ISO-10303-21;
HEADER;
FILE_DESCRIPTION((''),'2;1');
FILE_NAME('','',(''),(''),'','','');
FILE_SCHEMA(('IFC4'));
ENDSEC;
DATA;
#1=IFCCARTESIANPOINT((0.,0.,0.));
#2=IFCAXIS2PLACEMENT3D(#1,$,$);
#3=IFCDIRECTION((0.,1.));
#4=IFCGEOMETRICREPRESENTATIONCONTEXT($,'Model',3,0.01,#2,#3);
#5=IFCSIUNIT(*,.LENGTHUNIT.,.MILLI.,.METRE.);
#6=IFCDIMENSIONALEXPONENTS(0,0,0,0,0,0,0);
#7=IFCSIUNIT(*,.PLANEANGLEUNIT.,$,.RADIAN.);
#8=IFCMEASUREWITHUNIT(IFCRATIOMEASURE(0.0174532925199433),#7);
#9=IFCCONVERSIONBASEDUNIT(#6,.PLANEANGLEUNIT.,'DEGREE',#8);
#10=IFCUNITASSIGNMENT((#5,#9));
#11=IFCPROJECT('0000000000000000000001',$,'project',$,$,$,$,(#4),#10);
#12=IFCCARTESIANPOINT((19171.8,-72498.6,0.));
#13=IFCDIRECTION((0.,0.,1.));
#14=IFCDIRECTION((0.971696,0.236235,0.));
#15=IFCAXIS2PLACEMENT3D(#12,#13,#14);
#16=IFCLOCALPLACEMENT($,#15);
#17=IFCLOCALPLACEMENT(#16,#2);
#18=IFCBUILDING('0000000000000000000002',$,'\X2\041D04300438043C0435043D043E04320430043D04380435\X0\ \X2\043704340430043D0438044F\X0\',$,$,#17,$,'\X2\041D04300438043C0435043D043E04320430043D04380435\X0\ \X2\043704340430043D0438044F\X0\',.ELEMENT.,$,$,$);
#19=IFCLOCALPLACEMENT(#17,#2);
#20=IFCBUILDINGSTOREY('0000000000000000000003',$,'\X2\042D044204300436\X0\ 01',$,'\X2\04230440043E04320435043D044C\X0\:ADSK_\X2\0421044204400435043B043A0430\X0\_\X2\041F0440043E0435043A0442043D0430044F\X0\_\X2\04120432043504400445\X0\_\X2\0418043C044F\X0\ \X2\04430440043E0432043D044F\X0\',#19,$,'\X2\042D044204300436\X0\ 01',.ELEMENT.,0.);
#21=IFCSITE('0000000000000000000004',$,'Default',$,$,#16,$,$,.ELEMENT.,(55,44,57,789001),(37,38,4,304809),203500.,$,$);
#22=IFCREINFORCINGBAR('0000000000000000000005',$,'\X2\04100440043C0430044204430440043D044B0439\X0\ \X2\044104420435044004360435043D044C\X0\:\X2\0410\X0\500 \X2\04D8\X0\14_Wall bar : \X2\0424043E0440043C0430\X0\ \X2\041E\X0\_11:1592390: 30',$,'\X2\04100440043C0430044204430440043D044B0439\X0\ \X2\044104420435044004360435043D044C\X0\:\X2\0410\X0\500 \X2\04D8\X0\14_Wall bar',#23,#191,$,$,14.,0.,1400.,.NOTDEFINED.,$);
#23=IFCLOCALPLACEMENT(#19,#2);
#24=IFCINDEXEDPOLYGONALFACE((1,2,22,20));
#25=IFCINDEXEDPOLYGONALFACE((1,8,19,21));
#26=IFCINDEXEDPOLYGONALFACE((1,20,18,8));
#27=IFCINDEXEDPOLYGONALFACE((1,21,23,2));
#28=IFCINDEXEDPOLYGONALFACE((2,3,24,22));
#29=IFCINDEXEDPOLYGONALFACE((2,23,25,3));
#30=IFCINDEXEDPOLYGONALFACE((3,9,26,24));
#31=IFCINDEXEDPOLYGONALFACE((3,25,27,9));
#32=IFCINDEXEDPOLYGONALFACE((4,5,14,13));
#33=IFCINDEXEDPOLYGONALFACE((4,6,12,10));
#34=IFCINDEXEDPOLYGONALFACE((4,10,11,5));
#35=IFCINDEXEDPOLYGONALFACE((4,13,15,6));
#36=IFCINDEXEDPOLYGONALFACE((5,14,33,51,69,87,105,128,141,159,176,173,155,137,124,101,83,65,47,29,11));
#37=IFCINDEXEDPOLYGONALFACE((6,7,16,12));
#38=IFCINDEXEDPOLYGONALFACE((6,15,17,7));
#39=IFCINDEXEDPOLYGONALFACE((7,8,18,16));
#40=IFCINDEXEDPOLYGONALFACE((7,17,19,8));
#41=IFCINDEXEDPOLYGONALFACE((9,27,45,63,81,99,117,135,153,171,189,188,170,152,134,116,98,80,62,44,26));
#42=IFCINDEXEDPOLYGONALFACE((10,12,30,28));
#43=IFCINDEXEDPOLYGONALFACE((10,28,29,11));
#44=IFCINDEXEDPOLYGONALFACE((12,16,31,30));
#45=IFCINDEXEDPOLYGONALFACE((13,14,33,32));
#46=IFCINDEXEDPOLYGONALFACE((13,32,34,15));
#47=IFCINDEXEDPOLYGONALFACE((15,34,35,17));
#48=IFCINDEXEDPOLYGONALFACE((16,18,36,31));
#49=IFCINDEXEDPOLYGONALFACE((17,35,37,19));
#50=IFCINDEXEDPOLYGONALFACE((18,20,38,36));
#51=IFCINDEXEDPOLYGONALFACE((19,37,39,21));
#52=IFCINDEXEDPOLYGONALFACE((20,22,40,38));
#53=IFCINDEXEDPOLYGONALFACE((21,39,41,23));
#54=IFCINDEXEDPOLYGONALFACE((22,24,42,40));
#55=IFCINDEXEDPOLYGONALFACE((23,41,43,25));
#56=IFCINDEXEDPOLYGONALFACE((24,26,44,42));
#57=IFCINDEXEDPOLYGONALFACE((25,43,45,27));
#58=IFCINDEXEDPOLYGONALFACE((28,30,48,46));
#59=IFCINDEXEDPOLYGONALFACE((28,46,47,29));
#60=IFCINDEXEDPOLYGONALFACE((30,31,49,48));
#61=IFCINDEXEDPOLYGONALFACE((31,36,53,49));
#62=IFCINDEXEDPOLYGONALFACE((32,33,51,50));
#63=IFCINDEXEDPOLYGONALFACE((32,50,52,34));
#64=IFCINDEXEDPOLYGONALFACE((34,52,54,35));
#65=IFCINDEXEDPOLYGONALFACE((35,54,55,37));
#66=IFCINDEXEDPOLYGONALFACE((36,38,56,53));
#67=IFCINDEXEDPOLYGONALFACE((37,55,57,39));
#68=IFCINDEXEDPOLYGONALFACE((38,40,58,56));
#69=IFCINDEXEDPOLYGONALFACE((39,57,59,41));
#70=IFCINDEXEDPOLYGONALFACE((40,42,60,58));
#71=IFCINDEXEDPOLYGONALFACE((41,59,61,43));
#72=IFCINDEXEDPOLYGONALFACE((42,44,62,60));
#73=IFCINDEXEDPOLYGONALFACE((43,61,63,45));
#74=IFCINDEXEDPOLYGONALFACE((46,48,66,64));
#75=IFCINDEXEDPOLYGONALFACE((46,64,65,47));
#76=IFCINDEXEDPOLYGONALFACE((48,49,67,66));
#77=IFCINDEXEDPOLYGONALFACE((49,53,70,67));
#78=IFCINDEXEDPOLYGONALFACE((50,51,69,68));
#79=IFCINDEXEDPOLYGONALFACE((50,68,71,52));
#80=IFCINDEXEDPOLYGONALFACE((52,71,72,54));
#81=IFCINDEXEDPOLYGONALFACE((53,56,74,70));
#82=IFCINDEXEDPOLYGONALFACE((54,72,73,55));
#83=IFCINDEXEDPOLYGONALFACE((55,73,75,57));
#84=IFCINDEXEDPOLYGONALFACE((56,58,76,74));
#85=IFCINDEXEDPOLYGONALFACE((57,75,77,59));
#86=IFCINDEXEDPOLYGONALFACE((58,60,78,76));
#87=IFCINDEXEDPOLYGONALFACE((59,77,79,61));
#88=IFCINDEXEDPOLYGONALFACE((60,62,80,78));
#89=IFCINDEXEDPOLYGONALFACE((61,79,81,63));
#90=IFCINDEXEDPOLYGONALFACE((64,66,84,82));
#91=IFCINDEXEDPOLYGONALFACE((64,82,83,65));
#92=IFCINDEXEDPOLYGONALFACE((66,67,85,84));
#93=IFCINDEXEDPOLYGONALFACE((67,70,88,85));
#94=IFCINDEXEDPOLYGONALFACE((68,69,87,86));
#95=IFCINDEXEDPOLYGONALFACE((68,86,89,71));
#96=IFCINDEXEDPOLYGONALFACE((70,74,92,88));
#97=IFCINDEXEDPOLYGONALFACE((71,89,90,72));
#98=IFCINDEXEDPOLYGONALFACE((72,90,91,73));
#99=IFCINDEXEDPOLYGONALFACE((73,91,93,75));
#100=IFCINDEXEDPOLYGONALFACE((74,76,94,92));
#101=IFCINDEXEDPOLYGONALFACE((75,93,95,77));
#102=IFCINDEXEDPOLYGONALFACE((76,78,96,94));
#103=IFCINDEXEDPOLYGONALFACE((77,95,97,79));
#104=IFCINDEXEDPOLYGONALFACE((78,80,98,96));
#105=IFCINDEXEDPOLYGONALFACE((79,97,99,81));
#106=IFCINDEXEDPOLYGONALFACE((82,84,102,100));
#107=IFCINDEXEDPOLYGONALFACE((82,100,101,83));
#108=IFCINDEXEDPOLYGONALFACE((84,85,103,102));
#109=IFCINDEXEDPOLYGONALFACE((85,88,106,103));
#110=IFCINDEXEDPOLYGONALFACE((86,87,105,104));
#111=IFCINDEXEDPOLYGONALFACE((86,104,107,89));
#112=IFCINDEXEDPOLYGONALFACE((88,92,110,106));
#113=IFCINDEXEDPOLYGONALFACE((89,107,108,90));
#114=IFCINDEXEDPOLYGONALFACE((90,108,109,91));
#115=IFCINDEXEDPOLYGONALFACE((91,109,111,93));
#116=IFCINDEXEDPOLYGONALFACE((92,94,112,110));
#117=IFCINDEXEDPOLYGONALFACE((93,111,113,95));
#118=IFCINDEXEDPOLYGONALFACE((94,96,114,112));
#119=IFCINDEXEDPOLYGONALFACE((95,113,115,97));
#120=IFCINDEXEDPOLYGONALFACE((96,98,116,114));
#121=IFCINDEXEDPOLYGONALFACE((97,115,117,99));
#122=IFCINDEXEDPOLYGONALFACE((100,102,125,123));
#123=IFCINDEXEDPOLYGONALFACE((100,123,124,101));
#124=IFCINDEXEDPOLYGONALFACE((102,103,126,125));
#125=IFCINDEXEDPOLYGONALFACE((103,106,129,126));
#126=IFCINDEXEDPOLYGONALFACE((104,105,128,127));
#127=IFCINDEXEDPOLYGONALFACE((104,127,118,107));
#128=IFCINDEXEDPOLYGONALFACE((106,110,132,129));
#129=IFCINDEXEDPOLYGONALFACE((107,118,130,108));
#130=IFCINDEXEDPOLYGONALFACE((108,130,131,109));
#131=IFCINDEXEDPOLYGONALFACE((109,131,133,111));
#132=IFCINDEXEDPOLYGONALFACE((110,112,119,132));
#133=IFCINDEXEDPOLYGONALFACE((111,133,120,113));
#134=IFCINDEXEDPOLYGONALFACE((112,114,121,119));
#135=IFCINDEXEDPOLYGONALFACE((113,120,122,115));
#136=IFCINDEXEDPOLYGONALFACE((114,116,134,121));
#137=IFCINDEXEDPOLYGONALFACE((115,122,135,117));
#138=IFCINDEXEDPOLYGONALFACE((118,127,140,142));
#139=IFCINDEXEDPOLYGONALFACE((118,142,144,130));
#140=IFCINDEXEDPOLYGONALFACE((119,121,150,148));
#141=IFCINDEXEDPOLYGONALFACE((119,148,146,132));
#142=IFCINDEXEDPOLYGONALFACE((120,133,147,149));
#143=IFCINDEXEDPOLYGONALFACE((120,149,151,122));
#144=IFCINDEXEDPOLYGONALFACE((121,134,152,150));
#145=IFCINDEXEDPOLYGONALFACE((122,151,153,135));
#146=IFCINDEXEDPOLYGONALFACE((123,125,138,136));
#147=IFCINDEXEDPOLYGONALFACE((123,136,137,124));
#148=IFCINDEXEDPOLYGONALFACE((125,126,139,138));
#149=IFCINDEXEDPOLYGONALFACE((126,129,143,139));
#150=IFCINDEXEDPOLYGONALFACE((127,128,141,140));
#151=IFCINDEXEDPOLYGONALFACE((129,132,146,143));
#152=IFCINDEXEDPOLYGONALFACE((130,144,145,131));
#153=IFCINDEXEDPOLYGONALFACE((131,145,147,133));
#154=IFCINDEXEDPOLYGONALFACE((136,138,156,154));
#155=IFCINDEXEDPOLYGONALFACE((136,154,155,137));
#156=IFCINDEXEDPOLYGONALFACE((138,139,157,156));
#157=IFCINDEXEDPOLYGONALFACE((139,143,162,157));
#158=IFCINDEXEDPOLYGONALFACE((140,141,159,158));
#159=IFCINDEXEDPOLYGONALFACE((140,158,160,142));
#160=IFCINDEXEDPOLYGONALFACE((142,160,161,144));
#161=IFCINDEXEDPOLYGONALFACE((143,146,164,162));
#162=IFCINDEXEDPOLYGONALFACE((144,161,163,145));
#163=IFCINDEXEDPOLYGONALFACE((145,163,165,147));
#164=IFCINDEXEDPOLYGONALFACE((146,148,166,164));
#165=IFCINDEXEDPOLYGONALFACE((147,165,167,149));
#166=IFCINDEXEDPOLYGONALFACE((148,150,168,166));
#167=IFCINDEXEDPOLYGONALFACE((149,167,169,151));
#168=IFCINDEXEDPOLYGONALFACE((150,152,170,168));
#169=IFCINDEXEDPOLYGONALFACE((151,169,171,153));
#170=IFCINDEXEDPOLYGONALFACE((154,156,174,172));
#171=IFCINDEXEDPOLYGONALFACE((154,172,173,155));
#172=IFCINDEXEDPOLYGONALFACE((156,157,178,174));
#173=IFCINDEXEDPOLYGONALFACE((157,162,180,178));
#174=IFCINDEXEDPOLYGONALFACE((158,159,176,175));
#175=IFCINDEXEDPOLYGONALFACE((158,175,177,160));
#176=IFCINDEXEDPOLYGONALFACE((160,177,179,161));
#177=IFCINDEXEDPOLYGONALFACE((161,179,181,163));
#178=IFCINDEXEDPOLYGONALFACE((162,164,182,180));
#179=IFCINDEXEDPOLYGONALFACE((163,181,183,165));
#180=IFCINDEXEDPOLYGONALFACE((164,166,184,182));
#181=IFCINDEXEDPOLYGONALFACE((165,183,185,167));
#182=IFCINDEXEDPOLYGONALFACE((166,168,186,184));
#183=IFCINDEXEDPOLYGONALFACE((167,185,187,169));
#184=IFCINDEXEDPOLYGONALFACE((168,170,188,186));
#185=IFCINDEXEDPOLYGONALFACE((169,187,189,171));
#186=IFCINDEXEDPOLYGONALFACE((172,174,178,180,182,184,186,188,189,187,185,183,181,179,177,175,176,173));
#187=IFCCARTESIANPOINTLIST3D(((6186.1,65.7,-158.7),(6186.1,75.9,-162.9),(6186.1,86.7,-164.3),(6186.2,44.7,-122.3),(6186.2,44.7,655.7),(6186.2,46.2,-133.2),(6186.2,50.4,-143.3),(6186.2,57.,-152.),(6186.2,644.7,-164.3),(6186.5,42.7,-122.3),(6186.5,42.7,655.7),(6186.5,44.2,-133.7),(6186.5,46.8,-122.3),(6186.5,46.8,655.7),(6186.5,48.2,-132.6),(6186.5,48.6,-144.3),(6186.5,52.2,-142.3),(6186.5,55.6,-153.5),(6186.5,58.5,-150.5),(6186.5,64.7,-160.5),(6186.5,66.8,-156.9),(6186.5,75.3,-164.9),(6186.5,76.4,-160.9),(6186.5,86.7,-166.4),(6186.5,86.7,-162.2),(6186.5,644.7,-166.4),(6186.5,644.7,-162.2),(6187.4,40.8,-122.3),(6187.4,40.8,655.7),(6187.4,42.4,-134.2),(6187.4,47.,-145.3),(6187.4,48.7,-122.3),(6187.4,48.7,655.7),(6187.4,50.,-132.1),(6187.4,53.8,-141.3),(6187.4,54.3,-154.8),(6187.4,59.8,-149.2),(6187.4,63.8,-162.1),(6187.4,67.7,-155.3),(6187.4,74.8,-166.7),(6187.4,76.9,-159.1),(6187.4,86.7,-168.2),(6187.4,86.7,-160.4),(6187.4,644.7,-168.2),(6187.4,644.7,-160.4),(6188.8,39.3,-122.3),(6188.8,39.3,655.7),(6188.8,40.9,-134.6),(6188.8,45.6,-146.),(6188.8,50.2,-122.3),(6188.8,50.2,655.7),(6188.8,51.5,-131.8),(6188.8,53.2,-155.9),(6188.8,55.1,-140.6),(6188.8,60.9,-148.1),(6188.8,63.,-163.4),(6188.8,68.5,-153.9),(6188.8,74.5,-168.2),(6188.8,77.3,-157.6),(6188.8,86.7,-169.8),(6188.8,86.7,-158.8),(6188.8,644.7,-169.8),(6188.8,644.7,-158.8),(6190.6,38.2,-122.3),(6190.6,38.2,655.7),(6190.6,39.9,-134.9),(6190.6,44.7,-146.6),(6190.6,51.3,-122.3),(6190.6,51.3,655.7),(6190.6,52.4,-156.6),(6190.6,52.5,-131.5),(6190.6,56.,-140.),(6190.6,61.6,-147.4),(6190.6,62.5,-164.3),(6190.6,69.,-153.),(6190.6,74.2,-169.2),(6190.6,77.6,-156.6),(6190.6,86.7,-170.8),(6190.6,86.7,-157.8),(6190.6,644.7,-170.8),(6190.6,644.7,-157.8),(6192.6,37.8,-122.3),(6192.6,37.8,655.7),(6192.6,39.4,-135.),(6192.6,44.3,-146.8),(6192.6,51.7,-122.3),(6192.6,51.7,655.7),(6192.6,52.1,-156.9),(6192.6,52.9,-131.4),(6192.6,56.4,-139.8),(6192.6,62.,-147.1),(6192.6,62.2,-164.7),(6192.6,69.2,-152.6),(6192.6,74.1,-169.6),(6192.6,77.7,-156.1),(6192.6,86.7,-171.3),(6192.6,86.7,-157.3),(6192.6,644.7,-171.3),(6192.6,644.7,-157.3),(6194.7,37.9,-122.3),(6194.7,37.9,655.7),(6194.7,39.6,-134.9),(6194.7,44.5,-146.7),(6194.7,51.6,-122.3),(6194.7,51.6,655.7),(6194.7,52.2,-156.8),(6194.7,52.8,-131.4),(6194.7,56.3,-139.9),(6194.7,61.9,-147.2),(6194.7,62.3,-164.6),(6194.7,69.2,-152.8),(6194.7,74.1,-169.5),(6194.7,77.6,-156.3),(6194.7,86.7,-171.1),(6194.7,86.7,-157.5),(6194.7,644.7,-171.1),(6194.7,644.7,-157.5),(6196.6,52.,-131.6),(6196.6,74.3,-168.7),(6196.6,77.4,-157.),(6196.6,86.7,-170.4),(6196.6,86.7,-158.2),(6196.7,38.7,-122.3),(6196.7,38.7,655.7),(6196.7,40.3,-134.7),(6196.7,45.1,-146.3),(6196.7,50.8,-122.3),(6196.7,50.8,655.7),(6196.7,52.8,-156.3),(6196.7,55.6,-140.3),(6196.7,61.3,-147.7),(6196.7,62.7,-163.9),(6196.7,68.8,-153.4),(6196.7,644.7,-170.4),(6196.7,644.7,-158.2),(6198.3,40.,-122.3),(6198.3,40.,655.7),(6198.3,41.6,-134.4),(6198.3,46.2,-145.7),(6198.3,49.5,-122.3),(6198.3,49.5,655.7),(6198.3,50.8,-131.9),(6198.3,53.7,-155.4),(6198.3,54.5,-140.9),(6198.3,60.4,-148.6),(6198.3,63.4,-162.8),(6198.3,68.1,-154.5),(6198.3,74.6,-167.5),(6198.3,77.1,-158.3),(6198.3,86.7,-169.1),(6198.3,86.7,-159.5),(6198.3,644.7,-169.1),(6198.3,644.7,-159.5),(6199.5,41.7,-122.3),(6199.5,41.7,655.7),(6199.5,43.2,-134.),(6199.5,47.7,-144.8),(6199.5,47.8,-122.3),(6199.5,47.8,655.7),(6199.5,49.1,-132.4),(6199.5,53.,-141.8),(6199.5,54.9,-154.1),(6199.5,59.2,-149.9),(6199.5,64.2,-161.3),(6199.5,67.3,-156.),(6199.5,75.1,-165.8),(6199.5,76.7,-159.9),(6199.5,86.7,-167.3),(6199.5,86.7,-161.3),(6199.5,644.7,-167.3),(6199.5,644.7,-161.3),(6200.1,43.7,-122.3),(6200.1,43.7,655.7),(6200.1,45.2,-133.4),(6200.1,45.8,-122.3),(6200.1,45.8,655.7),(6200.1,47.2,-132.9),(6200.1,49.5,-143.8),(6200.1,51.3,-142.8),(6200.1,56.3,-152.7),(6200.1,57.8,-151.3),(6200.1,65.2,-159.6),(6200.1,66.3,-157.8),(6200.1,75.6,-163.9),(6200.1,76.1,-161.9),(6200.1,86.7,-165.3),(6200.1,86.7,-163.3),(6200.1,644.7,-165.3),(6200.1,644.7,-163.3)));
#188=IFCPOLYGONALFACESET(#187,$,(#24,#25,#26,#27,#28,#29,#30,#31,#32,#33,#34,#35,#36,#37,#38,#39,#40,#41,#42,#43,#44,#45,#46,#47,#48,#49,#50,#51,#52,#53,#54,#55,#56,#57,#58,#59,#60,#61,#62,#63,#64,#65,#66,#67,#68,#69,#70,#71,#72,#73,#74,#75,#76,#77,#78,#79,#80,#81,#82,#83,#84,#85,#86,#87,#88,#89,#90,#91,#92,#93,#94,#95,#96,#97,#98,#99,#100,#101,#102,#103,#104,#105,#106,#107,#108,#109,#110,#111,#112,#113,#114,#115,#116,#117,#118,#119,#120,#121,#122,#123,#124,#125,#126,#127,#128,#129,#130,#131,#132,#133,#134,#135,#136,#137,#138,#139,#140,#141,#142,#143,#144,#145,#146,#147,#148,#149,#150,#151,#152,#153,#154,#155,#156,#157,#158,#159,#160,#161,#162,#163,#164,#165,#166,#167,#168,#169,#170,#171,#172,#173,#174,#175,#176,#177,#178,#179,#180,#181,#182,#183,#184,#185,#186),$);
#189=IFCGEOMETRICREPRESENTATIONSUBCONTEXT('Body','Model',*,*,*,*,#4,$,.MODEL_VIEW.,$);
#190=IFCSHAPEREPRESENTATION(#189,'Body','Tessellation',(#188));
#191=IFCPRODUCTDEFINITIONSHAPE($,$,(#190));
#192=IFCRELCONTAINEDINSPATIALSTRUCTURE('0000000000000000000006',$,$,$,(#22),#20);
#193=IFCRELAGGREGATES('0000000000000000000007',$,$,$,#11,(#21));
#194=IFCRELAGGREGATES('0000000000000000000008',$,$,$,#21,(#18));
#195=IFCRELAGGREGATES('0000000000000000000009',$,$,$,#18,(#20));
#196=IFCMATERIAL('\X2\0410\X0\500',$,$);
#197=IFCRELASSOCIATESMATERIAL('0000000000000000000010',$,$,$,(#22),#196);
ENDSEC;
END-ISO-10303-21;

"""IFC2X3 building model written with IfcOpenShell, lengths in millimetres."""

from ifc_helpers import new_model, entity, si_unit, converted_unit, direction, frame, origin, place, context, subcontext, project, spatial, material, element, save


model = new_model("IFC2X3")

# Units and contexts
model_context = context("Model", 3, precision=0.01, world=origin(), true_north=direction((0.0, 1.0)))
body_context = subcontext(model_context, "Body", "Model", "MODEL_VIEW")
ifc_project = project(units=[si_unit("LENGTHUNIT", "METRE", prefix="MILLI"), converted_unit("PLANEANGLEUNIT", "DEGREE", entity("IfcRatioMeasure", 0.0174532925199433), si_unit("PLANEANGLEUNIT", "RADIAN"), dimensions=[0, 0, 0, 0, 0, 0, 0])], contexts=[model_context])

# Site, building, storey
site_placement = place(None, frame((19171.8, -72498.6, 0.0), z_axis=(0.0, 0.0, 1.0), x_axis=(0.971696, 0.236235, 0.0)))
site = spatial("IfcSite", under=ifc_project, at=site_placement, Name="Default", CompositionType="ELEMENT", RefLatitude=(55, 44, 57, 789001), RefLongitude=(37, 38, 4, 304809), RefElevation=203500.0)
building_placement = place(site_placement, origin())
building = spatial("IfcBuilding", under=site, at=building_placement, Name="Наименование здания", LongName="Наименование здания", CompositionType="ELEMENT")
storey_placement = place(building_placement, origin())
storey = spatial("IfcBuildingStorey", under=building, at=storey_placement, Name="Этаж 01", ObjectType="Уровень:ADSK_Стрелка_Проектная_Вверх_Имя уровня", LongName="Этаж 01", CompositionType="ELEMENT", Elevation=0.0)

# Reinforcing bar
ifc_material = material(Name="А500")
placement = place(storey_placement, origin())
element("IfcReinforcingBar", 1, at=placement, inside=storey, material=ifc_material, Name="Арматурный стержень:А500 Ә14_Wall bar : Форма О_11:1592390: 30", ObjectType="Арматурный стержень:А500 Ә14_Wall bar", BarLength=1400.0, BarRole="NOTDEFINED", CrossSectionArea=0.0, NominalDiameter=14.0, context=body_context, shape_type="AdvancedSweptSolid", body=[
    entity("IfcSweptDiskSolid", entity("IfcCompositeCurve", [entity("IfcCompositeCurveSegment", "CONTINUOUS", True, entity("IfcPolyline", [entity("IfcCartesianPoint", [6193.1, 44.7, 655.7]), entity("IfcCartesianPoint", [6193.1, 44.7, -122.3])])), entity("IfcCompositeCurveSegment", "CONTINUOUS", True, entity("IfcTrimmedCurve", entity("IfcCircle", entity("IfcAxis2Placement3D", entity("IfcCartesianPoint", [6193.1, 86.7, -122.3]), entity("IfcDirection", [1.0, 0.0, 0.0]), entity("IfcDirection", [0.0, 0.0, -1.0])), 42.0), [entity("IfcParameterValue", 270.0)], [entity("IfcParameterValue", 360.0)], True, "PARAMETER")), entity("IfcCompositeCurveSegment", "CONTINUOUS", True, entity("IfcPolyline", [entity("IfcCartesianPoint", [6193.1, 86.7, -164.3]), entity("IfcCartesianPoint", [6193.1, 644.7, -164.3])]))], False), 7.0, None, 0.0, 92.0),
])

save(model, "model.ifc")
